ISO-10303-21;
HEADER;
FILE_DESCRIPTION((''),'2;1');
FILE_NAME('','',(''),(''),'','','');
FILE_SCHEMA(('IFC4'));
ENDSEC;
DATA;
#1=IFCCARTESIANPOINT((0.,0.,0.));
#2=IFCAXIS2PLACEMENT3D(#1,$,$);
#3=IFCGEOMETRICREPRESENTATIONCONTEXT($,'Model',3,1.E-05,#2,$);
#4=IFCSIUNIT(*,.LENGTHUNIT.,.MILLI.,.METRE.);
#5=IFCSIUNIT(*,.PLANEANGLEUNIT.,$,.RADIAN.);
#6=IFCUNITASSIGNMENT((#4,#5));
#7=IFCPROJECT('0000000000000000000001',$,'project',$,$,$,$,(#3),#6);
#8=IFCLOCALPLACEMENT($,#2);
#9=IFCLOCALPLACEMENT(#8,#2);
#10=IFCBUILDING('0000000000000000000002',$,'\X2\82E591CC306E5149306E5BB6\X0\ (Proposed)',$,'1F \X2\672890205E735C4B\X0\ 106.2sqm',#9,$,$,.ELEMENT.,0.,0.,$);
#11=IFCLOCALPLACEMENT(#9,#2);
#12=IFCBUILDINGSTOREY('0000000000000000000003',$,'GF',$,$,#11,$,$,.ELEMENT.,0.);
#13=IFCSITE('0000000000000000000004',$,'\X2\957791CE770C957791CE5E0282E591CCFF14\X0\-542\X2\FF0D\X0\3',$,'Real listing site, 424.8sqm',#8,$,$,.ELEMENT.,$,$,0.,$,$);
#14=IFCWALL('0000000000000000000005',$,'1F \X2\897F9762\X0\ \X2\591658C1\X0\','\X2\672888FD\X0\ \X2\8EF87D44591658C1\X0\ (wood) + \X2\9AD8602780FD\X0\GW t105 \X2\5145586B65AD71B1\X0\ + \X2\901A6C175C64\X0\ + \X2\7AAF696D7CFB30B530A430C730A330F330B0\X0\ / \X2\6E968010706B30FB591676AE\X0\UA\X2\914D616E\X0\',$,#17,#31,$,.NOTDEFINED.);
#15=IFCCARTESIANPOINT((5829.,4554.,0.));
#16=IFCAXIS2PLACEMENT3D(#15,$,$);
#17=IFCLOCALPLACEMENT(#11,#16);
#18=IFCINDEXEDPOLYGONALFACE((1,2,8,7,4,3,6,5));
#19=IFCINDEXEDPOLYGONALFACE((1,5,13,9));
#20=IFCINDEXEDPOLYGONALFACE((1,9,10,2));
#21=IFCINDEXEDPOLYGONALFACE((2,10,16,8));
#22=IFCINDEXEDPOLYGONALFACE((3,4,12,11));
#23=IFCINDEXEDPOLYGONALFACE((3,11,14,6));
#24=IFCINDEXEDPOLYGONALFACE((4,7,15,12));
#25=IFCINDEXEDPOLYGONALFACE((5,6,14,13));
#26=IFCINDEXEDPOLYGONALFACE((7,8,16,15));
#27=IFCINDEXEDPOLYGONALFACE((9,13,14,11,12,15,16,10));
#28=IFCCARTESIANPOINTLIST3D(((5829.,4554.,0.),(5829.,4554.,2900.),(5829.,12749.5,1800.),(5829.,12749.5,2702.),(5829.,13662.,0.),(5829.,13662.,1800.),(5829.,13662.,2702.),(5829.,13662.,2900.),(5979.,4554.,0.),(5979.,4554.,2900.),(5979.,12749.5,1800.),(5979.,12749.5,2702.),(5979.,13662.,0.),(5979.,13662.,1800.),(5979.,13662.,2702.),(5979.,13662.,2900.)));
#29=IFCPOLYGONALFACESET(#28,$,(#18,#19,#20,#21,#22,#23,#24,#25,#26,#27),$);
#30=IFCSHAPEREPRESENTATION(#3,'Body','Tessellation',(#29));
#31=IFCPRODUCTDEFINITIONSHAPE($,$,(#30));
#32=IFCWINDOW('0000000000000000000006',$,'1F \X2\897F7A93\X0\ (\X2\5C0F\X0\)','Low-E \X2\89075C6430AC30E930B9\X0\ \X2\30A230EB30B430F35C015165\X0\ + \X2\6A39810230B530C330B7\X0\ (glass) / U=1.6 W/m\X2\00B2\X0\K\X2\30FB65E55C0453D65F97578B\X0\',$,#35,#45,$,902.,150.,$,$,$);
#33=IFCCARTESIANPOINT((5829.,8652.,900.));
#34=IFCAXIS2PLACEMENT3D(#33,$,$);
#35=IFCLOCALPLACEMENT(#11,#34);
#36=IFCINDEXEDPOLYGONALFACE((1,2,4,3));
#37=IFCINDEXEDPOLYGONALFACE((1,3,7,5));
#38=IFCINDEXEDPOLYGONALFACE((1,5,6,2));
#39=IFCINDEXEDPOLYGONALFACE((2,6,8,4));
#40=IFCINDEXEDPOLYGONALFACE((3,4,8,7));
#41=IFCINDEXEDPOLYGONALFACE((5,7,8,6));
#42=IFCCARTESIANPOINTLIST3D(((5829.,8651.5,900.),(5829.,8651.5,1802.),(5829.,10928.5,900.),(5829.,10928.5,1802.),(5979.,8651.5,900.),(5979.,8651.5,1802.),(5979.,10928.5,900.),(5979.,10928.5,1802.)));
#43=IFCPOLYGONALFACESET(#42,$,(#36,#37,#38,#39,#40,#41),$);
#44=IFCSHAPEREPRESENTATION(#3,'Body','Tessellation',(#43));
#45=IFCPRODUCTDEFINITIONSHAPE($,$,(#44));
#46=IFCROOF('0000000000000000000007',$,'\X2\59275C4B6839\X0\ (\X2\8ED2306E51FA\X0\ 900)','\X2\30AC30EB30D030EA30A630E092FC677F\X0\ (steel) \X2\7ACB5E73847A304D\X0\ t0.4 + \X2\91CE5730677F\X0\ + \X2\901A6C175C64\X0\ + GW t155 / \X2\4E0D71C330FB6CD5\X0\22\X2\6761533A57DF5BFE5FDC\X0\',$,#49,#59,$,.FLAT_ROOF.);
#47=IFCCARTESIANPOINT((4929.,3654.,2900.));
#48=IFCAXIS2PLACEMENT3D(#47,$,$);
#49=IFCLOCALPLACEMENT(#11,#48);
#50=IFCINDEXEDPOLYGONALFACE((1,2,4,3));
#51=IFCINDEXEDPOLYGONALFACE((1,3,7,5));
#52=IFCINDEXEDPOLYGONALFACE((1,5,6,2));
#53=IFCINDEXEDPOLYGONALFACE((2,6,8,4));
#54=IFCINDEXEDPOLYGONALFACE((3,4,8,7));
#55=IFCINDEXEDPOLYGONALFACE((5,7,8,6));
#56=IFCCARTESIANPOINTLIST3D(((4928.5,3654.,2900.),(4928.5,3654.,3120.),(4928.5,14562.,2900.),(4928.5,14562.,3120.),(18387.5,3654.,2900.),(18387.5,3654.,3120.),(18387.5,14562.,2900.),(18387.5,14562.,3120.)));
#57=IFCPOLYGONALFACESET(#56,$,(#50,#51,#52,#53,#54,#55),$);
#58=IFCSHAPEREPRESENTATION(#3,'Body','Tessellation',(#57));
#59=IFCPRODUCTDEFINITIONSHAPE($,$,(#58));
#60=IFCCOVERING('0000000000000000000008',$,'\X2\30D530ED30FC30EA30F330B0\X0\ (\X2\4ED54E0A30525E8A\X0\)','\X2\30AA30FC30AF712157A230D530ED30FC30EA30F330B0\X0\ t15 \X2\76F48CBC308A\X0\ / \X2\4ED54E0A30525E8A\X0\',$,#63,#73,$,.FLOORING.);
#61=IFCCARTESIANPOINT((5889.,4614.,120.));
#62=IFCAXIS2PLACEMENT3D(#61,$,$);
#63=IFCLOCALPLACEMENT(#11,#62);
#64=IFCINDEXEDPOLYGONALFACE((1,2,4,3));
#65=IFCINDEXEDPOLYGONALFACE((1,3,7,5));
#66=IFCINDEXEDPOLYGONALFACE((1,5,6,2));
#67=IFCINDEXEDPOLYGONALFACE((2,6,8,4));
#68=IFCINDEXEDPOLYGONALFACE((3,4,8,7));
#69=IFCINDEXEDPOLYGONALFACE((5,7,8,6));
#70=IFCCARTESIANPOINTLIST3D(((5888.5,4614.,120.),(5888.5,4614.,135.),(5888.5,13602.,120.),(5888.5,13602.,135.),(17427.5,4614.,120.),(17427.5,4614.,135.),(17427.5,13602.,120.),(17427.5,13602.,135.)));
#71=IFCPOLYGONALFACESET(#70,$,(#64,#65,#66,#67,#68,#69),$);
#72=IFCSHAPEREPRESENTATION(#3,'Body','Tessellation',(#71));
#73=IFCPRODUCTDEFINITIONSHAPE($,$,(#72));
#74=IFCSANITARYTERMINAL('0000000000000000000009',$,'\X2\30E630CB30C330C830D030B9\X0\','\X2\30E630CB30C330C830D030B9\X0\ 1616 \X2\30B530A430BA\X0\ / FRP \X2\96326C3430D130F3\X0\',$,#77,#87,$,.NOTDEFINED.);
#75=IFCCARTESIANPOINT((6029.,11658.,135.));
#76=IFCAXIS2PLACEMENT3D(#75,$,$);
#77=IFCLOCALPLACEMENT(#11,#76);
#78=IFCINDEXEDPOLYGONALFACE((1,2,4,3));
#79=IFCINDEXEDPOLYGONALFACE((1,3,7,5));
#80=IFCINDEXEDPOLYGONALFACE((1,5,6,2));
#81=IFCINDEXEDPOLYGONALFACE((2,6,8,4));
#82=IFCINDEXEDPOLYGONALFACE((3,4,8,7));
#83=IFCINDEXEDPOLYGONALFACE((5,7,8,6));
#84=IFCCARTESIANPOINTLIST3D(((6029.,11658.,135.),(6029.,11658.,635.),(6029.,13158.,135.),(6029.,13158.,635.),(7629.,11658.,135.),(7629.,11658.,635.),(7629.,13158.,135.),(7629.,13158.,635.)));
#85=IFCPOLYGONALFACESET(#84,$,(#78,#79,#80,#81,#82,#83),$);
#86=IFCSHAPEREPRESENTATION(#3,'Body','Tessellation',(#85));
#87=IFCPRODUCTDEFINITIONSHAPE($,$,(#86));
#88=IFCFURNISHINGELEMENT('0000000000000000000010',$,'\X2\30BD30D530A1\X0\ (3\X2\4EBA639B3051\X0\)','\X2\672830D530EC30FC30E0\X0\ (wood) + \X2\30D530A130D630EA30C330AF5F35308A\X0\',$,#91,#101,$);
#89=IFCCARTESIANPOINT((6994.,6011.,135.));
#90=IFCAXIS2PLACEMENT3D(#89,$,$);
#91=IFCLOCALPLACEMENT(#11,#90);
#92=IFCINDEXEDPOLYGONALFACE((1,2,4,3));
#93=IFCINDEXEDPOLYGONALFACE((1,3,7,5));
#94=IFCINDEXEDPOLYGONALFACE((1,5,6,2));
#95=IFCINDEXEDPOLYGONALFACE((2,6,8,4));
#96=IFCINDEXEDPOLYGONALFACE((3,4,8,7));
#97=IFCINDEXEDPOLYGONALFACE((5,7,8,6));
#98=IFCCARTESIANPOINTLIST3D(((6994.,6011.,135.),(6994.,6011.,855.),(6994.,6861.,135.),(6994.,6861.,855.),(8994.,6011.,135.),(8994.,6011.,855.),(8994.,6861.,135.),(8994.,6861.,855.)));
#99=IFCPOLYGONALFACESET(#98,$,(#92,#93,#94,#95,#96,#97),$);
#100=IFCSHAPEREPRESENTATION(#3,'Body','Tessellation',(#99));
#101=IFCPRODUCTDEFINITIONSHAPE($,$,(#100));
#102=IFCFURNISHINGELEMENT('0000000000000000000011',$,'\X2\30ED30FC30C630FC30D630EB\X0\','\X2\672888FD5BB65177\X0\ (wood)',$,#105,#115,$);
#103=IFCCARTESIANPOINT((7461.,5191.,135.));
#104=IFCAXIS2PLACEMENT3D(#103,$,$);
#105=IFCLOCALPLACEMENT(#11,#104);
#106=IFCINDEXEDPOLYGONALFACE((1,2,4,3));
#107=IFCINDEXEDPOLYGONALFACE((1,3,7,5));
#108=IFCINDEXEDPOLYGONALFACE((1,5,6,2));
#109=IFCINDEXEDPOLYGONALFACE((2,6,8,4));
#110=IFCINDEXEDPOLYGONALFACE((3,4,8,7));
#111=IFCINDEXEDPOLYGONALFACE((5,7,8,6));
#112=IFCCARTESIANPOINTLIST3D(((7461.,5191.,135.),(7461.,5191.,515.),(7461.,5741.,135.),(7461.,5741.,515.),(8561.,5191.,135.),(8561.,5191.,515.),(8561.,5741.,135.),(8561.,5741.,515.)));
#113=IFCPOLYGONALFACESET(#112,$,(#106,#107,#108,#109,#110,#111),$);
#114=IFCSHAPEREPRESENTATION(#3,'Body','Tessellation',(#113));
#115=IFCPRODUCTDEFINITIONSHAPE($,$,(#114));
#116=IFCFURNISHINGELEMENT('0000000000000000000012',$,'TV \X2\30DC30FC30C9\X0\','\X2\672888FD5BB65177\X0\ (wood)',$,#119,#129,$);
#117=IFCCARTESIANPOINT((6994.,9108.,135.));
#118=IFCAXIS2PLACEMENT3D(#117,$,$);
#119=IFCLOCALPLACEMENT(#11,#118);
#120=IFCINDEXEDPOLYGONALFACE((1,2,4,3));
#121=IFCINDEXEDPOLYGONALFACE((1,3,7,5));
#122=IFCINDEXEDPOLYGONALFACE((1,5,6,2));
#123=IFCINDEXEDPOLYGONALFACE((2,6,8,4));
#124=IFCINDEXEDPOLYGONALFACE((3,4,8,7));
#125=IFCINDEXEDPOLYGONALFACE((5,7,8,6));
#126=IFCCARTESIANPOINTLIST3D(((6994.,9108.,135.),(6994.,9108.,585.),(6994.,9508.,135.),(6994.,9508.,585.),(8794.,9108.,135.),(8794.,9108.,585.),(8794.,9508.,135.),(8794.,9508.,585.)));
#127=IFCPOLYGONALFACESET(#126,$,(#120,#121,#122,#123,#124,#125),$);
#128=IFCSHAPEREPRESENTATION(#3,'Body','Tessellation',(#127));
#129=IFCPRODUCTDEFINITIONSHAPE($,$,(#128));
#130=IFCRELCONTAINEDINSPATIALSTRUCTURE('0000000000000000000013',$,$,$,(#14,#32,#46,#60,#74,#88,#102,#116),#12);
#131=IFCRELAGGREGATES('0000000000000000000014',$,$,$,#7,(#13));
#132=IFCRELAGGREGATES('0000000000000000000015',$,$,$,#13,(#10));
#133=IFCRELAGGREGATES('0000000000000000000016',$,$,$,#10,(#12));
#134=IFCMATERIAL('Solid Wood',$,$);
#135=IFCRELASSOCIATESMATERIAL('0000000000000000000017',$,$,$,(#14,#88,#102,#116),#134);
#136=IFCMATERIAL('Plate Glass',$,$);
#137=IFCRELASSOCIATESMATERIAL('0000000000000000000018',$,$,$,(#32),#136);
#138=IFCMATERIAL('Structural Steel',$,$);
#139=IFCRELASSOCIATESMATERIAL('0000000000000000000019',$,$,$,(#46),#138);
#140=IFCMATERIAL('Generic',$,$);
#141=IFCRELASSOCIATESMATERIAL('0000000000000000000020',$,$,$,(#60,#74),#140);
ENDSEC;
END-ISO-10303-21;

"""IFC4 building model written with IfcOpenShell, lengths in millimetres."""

from ifc_helpers import new_model, si_unit, frame, frame_2d, origin, place, context, project, spatial, rectangle, extrude, material, element, fill, save


model = new_model("IFC4")

# Units and contexts
model_context = context("Model", 3, precision=1e-05, world=origin())
ifc_project = project(units=[si_unit("LENGTHUNIT", "METRE", prefix="MILLI"), si_unit("PLANEANGLEUNIT", "RADIAN")], contexts=[model_context])

# Site, building, storey
site_placement = place(None, origin())
site = spatial("IfcSite", under=ifc_project, at=site_placement, Name="長野県長野市若里４-542－3", ObjectType="Real listing site, 424.8sqm", CompositionType="ELEMENT", RefElevation=0.0)
building_placement = place(site_placement, origin())
building = spatial("IfcBuilding", under=site, at=building_placement, Name="若里の光の家 (Proposed)", ObjectType="1F 木造平屋 106.2sqm", CompositionType="ELEMENT", ElevationOfRefHeight=0.0, ElevationOfTerrain=0.0)
storey_placement = place(building_placement, origin())
storey = spatial("IfcBuildingStorey", under=building, at=storey_placement, Name="GF", CompositionType="ELEMENT", Elevation=0.0)

# Shared definitions
ifc_material_1 = material(Name="Solid Wood")

# Shared definitions
ifc_material_2 = material(Name="Plate Glass")

# Wall, opening, window
wall_1_placement = place(storey_placement, frame((5829.0, 4554.0, 0.0)))
wall_1 = element("IfcWall", 1, at=wall_1_placement, inside=storey, material=ifc_material_1, Name="1F 西面 外壁", Description="木製 軸組外壁 (wood) + 高性能GW t105 充填断熱 + 通気層 + 窯業系サイディング / 準耐火・外皮UA配慮", PredefinedType="NOTDEFINED", context=model_context, shape_type="SweptSolid", body=[
    extrude(rectangle(XDim=150.0, YDim=9108.0, at=frame_2d((75.0, 4554.0))), frame((5829.0, 4554.0, 0.0)), (0.0, 0.0, 1.0), 2900.0),
])
opening_1_placement = place(storey_placement, frame((5829.0, 8652.0, 900.0)))
opening_1 = element("IfcOpeningElement", 2, at=opening_1_placement, cuts=wall_1, PredefinedType="NOTDEFINED", context=model_context, shape_type="SweptSolid", body=[
    extrude(rectangle(XDim=150.0, YDim=2277.0, at=frame_2d((75.0, 1138.0))), frame((5829.0, 8652.0, 900.0)), (0.0, 0.0, 1.0), 902.0),
])
window_1_placement = place(storey_placement, frame((5829.0, 8652.0, 900.0)))
window_1 = element("IfcWindow", 3, at=window_1_placement, inside=storey, material=ifc_material_2, Name="1F 西窓 (小)", Description="Low-E 複層ガラス アルゴン封入 + 樹脂サッシ (glass) / U=1.6 W/m²K・日射取得型", OverallHeight=902.0, OverallWidth=150.0, context=model_context, shape_type="SweptSolid", body=[
    extrude(rectangle(XDim=150.0, YDim=2277.0, at=frame_2d((75.0, 1138.0))), frame((5829.0, 8652.0, 900.0)), (0.0, 0.0, 1.0), 902.0),
])
fill(opening_1, window_1)

# Roof
ifc_material_3 = material(Name="Structural Steel")
roof_placement = place(storey_placement, frame((4929.0, 3654.0, 2900.0)))
element("IfcRoof", 4, at=roof_placement, inside=storey, material=ifc_material_3, Name="大屋根 (軒の出 900)", Description="ガルバリウム鋼板 (steel) 立平葺き t0.4 + 野地板 + 通気層 + GW t155 / 不燃・法22条区域対応", PredefinedType="FLAT_ROOF", context=model_context, shape_type="SweptSolid", body=[
    extrude(rectangle(XDim=13459.0, YDim=10908.0, at=frame_2d((6729.0, 5454.0))), frame((4929.0, 3654.0, 2900.0)), (0.0, 0.0, 1.0), 220.0),
])

# Covering
ifc_material_4 = material(Name="Generic")
covering_placement = place(storey_placement, frame((5889.0, 4614.0, 120.0)))
element("IfcCovering", 5, at=covering_placement, inside=storey, material=ifc_material_4, Name="フローリング (仕上げ床)", Description="オーク無垢フローリング t15 直貼り / 仕上げ床", PredefinedType="FLOORING", context=model_context, shape_type="SweptSolid", body=[
    extrude(rectangle(XDim=11539.0, YDim=8988.0, at=frame_2d((5769.0, 4494.0))), frame((5889.0, 4614.0, 120.0)), (0.0, 0.0, 1.0), 15.0),
])

# Sanitary terminal
sanitary_terminal_placement = place(storey_placement, frame((6029.0, 11658.0, 135.0)))
element("IfcSanitaryTerminal", 6, at=sanitary_terminal_placement, inside=storey, material=ifc_material_4, Name="ユニットバス", Description="ユニットバス 1616 サイズ / FRP 防水パン", PredefinedType="NOTDEFINED", context=model_context, shape_type="SweptSolid", body=[
    extrude(rectangle(XDim=1600.0, YDim=1500.0, at=frame_2d((800.0, 750.0))), frame((6029.0, 11658.0, 135.0)), (0.0, 0.0, 1.0), 500.0),
])

# Furnishing elements
furnishing_1_placement = place(storey_placement, frame((6994.0, 6011.0, 135.0)))
element("IfcFurnishingElement", 7, at=furnishing_1_placement, inside=storey, material=ifc_material_1, Name="ソファ (3人掛け)", Description="木フレーム (wood) + ファブリック張り", context=model_context, shape_type="SweptSolid", body=[
    extrude(rectangle(XDim=2000.0, YDim=850.0, at=frame_2d((1000.0, 425.0))), frame((6994.0, 6011.0, 135.0)), (0.0, 0.0, 1.0), 720.0),
])
furnishing_2_placement = place(storey_placement, frame((7461.0, 5191.0, 135.0)))
element("IfcFurnishingElement", 8, at=furnishing_2_placement, inside=storey, material=ifc_material_1, Name="ローテーブル", Description="木製家具 (wood)", context=model_context, shape_type="SweptSolid", body=[
    extrude(rectangle(XDim=1100.0, YDim=550.0, at=frame_2d((550.0, 275.0))), frame((7461.0, 5191.0, 135.0)), (0.0, 0.0, 1.0), 380.0),
])
furnishing_3_placement = place(storey_placement, frame((6994.0, 9108.0, 135.0)))
element("IfcFurnishingElement", 9, at=furnishing_3_placement, inside=storey, material=ifc_material_1, Name="TV ボード", Description="木製家具 (wood)", context=model_context, shape_type="SweptSolid", body=[
    extrude(rectangle(XDim=1800.0, YDim=400.0, at=frame_2d((900.0, 200.0))), frame((6994.0, 9108.0, 135.0)), (0.0, 0.0, 1.0), 450.0),
])

save(model, "model.ifc")
